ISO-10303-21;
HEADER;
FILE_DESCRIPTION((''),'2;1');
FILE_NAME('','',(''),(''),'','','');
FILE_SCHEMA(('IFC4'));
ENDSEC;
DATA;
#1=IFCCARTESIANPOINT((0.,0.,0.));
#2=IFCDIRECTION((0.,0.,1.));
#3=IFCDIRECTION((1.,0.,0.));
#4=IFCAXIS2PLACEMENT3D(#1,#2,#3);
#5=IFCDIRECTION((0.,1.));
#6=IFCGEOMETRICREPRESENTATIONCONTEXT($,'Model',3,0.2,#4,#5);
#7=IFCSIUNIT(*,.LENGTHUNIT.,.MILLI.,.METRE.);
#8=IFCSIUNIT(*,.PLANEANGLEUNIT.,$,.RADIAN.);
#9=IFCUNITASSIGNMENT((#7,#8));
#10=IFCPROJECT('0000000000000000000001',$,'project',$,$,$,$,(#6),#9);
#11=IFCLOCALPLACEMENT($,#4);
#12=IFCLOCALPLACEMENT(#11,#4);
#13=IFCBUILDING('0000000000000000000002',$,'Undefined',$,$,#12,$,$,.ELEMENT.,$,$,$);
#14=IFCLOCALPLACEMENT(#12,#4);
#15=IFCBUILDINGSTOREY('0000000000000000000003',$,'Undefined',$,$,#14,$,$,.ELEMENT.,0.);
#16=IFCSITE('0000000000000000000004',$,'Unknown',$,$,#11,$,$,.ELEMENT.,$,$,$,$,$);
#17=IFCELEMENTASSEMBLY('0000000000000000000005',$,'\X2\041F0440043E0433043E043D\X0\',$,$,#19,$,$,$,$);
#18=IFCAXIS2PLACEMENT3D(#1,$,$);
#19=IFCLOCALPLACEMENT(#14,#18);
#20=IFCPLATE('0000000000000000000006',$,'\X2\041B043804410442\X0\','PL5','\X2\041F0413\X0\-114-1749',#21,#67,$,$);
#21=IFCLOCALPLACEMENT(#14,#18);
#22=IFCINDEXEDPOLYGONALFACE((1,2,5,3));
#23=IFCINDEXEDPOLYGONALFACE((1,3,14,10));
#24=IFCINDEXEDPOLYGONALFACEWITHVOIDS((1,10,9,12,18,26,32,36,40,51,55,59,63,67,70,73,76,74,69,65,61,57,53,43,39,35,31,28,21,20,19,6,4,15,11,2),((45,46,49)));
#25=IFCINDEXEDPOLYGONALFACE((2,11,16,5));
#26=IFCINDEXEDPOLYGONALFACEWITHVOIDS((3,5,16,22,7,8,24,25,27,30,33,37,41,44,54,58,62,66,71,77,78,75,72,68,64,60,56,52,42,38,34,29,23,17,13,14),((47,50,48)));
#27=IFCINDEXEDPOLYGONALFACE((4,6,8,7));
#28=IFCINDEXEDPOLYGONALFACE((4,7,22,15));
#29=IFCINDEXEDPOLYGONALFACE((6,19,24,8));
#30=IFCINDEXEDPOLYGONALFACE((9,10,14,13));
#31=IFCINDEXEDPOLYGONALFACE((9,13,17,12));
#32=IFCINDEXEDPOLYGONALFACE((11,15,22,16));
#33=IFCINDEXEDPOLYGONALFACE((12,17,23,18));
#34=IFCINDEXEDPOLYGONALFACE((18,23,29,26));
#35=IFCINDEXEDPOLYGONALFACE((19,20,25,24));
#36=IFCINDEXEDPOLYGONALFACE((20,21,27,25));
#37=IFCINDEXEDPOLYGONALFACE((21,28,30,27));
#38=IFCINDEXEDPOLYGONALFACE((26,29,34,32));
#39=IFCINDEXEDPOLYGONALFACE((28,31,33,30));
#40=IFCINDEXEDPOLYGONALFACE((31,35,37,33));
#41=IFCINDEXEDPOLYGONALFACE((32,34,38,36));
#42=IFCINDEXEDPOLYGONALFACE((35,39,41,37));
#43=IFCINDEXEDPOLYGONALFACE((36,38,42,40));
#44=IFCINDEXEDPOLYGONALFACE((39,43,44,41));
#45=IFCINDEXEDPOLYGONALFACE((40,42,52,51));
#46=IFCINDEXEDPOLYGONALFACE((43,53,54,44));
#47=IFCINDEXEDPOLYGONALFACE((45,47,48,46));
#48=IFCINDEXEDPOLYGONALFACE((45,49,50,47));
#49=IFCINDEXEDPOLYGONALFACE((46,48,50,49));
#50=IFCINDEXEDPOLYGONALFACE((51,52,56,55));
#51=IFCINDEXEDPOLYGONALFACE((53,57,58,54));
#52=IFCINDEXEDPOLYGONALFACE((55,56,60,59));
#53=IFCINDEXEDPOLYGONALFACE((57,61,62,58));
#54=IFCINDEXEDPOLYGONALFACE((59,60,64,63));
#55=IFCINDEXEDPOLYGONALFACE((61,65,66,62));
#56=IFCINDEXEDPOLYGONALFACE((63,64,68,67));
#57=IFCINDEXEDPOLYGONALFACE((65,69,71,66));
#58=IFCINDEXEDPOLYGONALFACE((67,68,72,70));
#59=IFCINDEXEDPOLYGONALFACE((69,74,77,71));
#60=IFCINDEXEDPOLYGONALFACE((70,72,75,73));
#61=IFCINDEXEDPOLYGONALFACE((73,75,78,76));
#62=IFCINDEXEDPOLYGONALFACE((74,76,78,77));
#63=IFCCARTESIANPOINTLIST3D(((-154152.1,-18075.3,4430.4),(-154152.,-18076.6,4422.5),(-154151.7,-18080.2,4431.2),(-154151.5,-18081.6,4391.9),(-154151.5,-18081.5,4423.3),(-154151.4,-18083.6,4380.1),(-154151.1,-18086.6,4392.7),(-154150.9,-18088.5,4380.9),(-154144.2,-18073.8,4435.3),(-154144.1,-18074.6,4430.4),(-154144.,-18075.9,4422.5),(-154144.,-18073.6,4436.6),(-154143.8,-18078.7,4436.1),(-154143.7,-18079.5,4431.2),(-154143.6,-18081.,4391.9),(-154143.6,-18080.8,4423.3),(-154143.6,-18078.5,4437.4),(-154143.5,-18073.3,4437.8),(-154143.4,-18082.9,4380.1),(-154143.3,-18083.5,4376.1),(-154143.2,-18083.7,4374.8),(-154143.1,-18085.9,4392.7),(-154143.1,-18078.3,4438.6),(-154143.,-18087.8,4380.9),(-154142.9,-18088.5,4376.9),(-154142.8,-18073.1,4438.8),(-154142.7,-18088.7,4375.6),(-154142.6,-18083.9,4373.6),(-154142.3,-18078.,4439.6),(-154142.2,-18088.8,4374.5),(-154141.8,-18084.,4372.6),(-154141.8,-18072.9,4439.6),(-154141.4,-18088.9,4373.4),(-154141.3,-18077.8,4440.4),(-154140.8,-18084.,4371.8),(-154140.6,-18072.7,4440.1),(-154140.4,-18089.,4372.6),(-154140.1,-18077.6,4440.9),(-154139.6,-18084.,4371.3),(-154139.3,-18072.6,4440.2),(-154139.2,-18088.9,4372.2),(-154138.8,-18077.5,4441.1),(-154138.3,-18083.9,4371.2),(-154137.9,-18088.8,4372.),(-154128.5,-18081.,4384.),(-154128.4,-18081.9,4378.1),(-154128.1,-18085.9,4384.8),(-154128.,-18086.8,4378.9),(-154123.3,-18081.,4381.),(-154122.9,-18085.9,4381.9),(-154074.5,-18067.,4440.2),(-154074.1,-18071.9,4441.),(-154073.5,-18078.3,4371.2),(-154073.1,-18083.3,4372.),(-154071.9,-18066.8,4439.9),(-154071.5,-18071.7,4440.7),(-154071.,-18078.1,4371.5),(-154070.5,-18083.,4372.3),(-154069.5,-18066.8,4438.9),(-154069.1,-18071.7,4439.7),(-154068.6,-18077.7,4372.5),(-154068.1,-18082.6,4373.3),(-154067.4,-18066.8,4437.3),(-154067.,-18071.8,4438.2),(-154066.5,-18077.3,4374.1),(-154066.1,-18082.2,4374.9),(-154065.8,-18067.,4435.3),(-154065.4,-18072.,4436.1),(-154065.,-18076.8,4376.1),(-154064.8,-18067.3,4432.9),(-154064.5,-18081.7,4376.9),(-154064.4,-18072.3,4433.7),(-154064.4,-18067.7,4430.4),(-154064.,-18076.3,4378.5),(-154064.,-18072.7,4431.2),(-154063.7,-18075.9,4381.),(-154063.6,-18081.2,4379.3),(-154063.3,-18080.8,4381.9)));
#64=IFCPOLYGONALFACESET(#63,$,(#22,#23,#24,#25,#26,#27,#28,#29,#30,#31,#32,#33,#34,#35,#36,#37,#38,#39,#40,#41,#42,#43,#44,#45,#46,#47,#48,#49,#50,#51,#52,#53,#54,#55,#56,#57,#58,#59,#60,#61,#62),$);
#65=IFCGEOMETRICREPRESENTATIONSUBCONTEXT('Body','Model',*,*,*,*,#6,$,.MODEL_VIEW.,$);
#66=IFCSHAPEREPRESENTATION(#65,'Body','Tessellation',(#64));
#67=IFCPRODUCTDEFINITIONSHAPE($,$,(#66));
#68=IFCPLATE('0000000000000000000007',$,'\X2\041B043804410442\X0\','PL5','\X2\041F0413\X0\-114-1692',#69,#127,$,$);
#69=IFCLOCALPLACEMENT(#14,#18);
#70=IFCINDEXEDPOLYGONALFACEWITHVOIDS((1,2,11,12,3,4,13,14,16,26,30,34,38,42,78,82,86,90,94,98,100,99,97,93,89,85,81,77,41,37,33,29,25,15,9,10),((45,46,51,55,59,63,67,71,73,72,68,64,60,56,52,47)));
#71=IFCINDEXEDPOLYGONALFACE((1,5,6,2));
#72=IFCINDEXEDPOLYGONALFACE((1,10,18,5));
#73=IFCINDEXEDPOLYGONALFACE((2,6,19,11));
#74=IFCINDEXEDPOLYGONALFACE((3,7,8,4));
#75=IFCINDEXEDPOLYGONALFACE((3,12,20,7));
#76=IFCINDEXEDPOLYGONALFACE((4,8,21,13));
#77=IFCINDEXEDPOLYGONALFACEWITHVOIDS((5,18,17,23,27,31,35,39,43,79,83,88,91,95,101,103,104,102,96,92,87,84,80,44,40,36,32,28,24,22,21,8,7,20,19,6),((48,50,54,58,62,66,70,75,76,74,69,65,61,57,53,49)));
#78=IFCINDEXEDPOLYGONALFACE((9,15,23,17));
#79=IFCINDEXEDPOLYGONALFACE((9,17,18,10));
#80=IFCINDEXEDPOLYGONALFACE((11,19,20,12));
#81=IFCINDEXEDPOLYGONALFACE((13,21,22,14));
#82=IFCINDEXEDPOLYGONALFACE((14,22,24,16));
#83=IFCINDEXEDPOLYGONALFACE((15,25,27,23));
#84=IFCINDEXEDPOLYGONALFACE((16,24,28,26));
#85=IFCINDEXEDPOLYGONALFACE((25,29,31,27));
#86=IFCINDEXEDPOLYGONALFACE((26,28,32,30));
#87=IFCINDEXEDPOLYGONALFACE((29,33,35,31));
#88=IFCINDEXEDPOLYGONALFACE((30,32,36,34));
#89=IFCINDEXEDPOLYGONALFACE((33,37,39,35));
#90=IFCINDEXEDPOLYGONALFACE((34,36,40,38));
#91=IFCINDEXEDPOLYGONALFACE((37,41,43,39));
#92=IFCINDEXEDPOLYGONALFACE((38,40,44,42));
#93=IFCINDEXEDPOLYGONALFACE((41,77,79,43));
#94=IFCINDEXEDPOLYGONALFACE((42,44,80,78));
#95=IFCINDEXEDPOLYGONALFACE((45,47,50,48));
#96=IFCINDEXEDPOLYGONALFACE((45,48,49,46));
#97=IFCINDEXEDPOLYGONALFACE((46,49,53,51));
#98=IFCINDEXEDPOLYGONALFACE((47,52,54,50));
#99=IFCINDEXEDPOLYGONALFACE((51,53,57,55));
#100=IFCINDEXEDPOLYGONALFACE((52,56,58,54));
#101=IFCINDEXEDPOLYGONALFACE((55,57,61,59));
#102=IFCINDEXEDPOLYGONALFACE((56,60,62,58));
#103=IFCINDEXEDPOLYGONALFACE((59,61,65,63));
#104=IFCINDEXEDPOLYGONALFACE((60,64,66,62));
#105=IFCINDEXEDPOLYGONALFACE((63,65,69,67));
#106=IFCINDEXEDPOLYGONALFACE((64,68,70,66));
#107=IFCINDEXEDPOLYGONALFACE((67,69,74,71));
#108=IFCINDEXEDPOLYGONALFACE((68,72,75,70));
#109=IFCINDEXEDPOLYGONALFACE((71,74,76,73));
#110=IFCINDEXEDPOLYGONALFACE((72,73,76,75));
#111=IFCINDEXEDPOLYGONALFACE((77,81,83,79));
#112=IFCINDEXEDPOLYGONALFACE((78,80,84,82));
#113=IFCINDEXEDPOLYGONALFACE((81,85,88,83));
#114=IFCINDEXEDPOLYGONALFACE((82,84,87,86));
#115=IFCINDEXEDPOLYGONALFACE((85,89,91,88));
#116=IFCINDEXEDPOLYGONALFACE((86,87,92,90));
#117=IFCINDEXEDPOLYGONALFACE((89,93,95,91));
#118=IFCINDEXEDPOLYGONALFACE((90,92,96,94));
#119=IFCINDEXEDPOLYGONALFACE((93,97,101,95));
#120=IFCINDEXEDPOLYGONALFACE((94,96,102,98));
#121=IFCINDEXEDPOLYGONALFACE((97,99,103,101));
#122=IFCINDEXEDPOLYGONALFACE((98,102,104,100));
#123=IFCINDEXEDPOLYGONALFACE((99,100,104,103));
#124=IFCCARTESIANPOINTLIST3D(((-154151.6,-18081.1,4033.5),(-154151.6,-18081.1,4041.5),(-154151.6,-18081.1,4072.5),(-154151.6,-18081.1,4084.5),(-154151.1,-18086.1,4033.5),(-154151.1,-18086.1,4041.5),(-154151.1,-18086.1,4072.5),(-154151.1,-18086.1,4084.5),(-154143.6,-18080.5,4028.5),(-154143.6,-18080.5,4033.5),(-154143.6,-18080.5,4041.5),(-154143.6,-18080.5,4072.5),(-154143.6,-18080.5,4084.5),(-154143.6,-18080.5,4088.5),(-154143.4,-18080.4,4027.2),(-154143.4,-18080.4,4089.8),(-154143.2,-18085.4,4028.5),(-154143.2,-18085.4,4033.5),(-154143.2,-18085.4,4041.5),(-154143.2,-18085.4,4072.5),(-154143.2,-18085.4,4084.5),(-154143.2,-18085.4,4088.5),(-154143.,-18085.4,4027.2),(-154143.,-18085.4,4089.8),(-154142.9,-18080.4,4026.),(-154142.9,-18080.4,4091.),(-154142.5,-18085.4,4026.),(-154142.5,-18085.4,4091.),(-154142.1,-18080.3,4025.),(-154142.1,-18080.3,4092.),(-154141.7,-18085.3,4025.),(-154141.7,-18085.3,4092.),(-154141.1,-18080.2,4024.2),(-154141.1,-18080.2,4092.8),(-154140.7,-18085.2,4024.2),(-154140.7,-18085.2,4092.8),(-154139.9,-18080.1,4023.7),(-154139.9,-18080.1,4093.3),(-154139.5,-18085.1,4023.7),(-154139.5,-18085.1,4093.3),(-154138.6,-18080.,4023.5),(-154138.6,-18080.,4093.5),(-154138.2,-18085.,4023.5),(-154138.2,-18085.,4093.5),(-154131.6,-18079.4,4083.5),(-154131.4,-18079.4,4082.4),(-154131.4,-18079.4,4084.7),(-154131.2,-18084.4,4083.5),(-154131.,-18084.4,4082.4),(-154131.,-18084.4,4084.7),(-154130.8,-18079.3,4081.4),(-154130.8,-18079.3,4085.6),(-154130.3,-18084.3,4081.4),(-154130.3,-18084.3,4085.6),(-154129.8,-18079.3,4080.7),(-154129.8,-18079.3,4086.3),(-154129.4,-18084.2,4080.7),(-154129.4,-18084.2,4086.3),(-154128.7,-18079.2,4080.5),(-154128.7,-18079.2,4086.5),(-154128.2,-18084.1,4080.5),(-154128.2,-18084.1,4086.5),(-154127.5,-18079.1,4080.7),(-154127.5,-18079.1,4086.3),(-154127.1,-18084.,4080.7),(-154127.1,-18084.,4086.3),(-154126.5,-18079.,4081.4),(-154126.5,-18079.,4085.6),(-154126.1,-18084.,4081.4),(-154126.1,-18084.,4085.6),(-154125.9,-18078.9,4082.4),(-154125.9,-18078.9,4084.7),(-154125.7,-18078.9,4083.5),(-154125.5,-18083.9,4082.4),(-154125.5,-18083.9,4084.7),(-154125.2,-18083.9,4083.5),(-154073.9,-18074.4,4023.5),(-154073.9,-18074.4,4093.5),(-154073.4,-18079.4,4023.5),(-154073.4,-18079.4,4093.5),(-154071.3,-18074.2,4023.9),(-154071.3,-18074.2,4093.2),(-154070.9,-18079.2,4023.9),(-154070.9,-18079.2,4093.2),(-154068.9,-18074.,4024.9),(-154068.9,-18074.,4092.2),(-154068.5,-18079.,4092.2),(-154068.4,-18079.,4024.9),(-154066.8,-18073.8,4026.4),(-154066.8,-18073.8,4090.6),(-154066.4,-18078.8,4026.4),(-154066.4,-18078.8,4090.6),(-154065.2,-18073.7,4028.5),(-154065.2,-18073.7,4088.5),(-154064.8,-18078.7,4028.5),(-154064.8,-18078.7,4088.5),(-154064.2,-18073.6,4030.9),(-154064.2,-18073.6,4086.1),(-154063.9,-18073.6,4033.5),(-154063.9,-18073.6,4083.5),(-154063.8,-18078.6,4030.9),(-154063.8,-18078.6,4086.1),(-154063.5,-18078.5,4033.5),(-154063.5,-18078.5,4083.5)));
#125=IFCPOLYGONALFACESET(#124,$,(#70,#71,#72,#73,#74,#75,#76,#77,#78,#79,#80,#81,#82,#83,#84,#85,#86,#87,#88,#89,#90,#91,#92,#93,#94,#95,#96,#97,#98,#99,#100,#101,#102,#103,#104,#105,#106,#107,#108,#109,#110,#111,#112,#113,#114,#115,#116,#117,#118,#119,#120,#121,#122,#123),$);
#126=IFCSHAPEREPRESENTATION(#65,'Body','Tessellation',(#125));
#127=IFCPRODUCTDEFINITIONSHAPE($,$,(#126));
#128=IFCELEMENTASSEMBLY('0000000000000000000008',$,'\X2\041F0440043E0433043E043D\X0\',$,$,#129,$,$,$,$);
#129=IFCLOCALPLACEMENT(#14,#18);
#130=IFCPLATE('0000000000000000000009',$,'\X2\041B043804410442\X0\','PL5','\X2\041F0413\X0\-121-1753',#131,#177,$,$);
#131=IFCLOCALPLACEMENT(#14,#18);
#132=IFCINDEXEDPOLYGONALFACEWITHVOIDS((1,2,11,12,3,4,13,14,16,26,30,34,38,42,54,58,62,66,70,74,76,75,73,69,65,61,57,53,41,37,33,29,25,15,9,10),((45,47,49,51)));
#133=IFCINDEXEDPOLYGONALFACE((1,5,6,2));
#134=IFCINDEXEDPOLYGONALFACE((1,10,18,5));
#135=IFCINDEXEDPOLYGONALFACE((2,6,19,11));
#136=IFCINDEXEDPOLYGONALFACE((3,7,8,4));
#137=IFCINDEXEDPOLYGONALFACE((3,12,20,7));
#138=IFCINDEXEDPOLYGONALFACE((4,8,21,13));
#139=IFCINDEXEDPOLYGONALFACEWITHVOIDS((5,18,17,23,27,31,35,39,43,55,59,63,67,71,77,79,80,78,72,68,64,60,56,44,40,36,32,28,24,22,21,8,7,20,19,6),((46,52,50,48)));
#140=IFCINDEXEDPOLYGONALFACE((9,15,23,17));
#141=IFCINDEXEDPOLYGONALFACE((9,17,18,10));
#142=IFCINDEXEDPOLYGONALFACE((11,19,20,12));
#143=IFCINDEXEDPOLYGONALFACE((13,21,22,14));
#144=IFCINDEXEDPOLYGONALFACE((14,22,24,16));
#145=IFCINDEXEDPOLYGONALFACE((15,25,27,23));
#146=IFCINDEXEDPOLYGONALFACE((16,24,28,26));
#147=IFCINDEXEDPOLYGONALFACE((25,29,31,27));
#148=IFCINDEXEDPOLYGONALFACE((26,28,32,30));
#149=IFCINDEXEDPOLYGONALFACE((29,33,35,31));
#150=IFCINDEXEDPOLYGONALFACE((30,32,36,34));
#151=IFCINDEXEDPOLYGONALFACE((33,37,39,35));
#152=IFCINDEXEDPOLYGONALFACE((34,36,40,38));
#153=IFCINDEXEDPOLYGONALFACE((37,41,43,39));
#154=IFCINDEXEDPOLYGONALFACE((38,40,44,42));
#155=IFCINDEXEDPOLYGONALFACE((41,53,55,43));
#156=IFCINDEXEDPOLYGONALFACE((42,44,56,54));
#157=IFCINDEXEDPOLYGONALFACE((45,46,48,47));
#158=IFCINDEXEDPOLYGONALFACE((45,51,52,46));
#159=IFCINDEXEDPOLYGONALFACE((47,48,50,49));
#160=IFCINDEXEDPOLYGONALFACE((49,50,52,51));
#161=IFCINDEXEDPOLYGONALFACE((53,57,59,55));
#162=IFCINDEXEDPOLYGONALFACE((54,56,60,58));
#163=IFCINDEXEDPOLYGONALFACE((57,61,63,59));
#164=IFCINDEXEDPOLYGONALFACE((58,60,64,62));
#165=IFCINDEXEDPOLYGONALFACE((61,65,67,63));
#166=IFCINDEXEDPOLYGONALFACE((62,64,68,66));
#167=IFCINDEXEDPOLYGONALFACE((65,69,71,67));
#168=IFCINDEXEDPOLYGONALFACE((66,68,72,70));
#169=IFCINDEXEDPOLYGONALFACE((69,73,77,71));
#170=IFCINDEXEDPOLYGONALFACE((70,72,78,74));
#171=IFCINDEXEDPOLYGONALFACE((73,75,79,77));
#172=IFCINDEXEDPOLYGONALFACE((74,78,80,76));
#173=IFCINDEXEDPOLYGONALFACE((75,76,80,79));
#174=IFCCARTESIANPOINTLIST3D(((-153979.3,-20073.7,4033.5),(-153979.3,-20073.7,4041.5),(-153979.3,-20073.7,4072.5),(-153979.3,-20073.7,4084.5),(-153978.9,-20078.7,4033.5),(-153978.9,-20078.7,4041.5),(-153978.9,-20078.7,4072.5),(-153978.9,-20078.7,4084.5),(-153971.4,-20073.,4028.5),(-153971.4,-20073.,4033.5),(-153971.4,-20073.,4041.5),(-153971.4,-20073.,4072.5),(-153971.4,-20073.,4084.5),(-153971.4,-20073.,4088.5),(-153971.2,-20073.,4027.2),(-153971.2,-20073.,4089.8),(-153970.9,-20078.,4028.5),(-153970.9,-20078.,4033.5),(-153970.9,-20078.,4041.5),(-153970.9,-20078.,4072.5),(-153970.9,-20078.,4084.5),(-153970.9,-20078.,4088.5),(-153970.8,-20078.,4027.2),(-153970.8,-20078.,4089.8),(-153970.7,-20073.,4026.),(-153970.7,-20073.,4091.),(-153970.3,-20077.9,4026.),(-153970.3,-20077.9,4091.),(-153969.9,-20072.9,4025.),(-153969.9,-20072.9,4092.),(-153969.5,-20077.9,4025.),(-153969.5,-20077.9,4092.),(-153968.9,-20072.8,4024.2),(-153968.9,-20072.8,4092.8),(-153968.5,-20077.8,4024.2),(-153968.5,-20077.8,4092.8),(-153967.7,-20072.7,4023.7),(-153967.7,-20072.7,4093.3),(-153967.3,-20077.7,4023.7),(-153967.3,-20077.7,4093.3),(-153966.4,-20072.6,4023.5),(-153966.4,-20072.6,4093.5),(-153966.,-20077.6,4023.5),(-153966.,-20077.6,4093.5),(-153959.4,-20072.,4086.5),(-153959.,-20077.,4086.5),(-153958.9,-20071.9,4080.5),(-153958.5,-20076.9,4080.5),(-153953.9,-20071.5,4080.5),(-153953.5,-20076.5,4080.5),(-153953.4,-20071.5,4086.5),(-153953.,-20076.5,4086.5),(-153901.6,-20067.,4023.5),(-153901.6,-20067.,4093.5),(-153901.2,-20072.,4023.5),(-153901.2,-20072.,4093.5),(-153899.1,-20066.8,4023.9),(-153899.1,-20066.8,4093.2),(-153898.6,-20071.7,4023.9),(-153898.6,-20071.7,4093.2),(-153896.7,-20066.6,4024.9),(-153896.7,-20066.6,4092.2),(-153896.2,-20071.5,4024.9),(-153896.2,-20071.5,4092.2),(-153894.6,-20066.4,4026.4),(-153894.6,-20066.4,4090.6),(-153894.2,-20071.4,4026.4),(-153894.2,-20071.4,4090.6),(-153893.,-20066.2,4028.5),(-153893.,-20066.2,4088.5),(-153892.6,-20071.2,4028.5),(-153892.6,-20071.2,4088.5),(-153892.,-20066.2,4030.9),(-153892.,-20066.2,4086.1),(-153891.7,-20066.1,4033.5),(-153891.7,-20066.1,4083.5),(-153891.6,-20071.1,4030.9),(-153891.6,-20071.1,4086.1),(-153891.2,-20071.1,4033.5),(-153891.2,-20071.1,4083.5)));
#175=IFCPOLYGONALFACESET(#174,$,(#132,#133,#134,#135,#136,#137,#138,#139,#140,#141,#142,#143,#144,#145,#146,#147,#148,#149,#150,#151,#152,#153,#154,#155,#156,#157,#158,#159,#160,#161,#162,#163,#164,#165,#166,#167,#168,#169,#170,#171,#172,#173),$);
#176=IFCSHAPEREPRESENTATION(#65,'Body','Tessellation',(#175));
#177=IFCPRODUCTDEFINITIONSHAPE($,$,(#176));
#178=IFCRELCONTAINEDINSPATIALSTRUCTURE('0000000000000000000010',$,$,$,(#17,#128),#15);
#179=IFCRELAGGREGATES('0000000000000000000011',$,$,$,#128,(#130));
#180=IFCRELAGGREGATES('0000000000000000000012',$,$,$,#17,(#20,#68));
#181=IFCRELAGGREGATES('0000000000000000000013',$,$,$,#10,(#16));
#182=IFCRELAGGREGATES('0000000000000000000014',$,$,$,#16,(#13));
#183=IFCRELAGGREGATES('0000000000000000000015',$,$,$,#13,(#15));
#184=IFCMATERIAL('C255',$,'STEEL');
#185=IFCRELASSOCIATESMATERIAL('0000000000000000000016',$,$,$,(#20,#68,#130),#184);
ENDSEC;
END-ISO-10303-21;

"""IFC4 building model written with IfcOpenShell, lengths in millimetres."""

from ifc_helpers import new_model, si_unit, direction, frame, origin_with_axes, place, context, subcontext, project, spatial, line, arc, indexed_curve, outline, extrude, material, element, aggregate, save


model = new_model("IFC4")

# Units and contexts
model_context = context("Model", 3, precision=0.2, world=origin_with_axes(), true_north=direction((0.0, 1.0)))
body_context = subcontext(model_context, "Body", "Model", "MODEL_VIEW")
ifc_project = project(units=[si_unit("LENGTHUNIT", "METRE", prefix="MILLI"), si_unit("PLANEANGLEUNIT", "RADIAN")], contexts=[model_context])

# Site, building, storey
site_placement = place(None, origin_with_axes())
site = spatial("IfcSite", under=ifc_project, at=site_placement, Name="Unknown", CompositionType="ELEMENT")
building_placement = place(site_placement, origin_with_axes())
building = spatial("IfcBuilding", under=site, at=building_placement, Name="Undefined", CompositionType="ELEMENT")
storey_placement = place(building_placement, origin_with_axes())
storey = spatial("IfcBuildingStorey", under=building, at=storey_placement, Name="Undefined", CompositionType="ELEMENT", Elevation=0.0)

# Shared definitions
ifc_material_1 = material(Name="C255", Category="STEEL")

# Element assembly, plates, voiding features
assembly_1_placement = place(storey_placement, frame((-154183.2, -18086.4, 3718.5), z_axis=(0.086114, -0.996285, 0.0), x_axis=(0.0, 0.0, 1.0)))
assembly_1 = element("IfcElementAssembly", 1, at=assembly_1_placement, inside=storey, Name="Прогон")
plate_1_placement = place(assembly_1_placement, frame((722.1, -120.0, -7.5), z_axis=(-0.162881, -0.000054, -0.986646), x_axis=(-0.986646, 0.000078, 0.162881)))
plate_1 = element("IfcPlate", 2, at=plate_1_placement, material=ifc_material_1, Name="Лист", Description="PL5", ObjectType="ПГ-114-1749", context=body_context, shape_type="SolidModel", body=[
    extrude(outline(indexed_curve([(0.0, 10.0), (2.9, 2.9), (10.0, 0.0), (60.0, 0.0), (67.1, 2.9), (70.0, 10.0), (70.0, 75.0), (68.5, 78.5), (65.0, 80.0), (61.0, 80.0), (61.0, 88.0), (49.0, 88.0), (49.0, 80.0), (18.0, 80.0), (18.0, 88.0), (10.0, 88.0), (10.0, 80.0), (5.0, 80.0), (1.5, 78.5), (0.0, 75.0)], segments=[arc(1, 2, 3), line(3, 4), arc(4, 5, 6), line(6, 7), arc(7, 8, 9), line(9, 10, 11, 12, 13, 14, 15, 16, 17, 18), arc(18, 19, 20), line(20, 1)])), frame((0.0, 0.0, 2.5), z_axis=(0.0, 0.0, 1.0), x_axis=(1.0, 0.0, 0.0)), (0.0, 0.0, -1.0), 5.0),
])
voiding_feature_1_placement = place(plate_1_placement, frame((60.0, 65.0, 6.0), z_axis=(-0.000054, -1.0, 0.000034), x_axis=(0.0, -0.000034, -1.0)))
element("IfcVoidingFeature", 3, at=voiding_feature_1_placement, cuts=plate_1, Name="Балка", ObjectType="(?)", PredefinedType="HOLE", context=body_context, shape_type="SolidModel", body=[
    extrude(outline(indexed_curve([(0.0, -3.0), (5.2, 0.0), (0.0, 3.0)], segments=[line(1, 2, 3, 1)])), frame((0.0, 0.0, 0.0), z_axis=(-1.0, 0.0, 0.0), x_axis=(0.0, 0.0, 1.0)), (0.0, 0.0, -1.0), 12.0),
])
plate_2_placement = place(assembly_1_placement, frame((305.0, -120.0, 0.0), z_axis=(0.0, -0.000057, 1.0), x_axis=(1.0, 0.000024, 0.0)))
plate_2 = element("IfcPlate", 4, at=plate_2_placement, material=ifc_material_1, Name="Лист", Description="PL5", ObjectType="ПГ-114-1692", context=body_context, shape_type="SolidModel", body=[
    extrude(outline(indexed_curve([(0.0, 10.0), (2.9, 2.9), (10.0, 0.0), (60.0, 0.0), (67.1, 2.9), (70.0, 10.0), (70.0, 75.0), (68.5, 78.5), (65.0, 80.0), (61.0, 80.0), (61.0, 88.0), (49.0, 88.0), (49.0, 80.0), (18.0, 80.0), (18.0, 88.0), (10.0, 88.0), (10.0, 80.0), (5.0, 80.0), (1.5, 78.5), (0.0, 75.0)], segments=[arc(1, 2, 3), line(3, 4), arc(4, 5, 6), line(6, 7), arc(7, 8, 9), line(9, 10, 11, 12, 13, 14, 15, 16, 17, 18), arc(18, 19, 20), line(20, 1)])), frame((0.0, 0.0, 2.5), z_axis=(0.0, 0.0, 1.0), x_axis=(1.0, 0.0, 0.0)), (0.0, 0.0, -1.0), 5.0),
])
voiding_feature_2_placement = place(plate_2_placement, frame((60.0, 65.0, 6.0), z_axis=(-0.000054, -1.0, 0.000034), x_axis=(0.0, -0.000034, -1.0)))
element("IfcVoidingFeature", 5, at=voiding_feature_2_placement, cuts=plate_2, Name="Балка", ObjectType="(?)", PredefinedType="HOLE", context=body_context, shape_type="SolidModel", body=[
    extrude(outline(indexed_curve([(3.0, 0.0), (2.8, 1.1), (2.1, 2.1), (1.1, 2.8), (0.0, 3.0), (-1.1, 2.8), (-2.1, 2.1), (-2.8, 1.1), (-3.0, 0.0), (-2.8, -1.1), (-2.1, -2.1), (-1.1, -2.8), (0.0, -3.0), (1.1, -2.8), (2.1, -2.1), (2.8, -1.1)], segments=[line(1, 2, 3, 4, 5, 6, 7, 8, 9, 10, 11, 12, 13, 14, 15, 16, 1)])), frame((0.0, 0.0, 0.0), z_axis=(-1.0, 0.0, 0.0), x_axis=(0.0, 0.0, 1.0)), (0.0, 0.0, -1.0), 12.0),
])

# Element assembly, plate, voiding feature
assembly_2_placement = place(storey_placement, frame((-154011.0, -20079.0, 3798.5), z_axis=(0.086114, -0.996285, 0.0), x_axis=(0.0, 0.0, 1.0)))
assembly_2 = element("IfcElementAssembly", 6, at=assembly_2_placement, inside=storey, Name="Прогон")
plate_3_placement = place(assembly_2_placement, frame((225.0, -120.0, 0.0), z_axis=(0.0, -0.000057, 1.0), x_axis=(1.0, 0.000024, 0.0)))
plate_3 = element("IfcPlate", 7, at=plate_3_placement, material=ifc_material_1, Name="Лист", Description="PL5", ObjectType="ПГ-121-1753", context=body_context, shape_type="SolidModel", body=[
    extrude(outline(indexed_curve([(0.0, 10.0), (2.9, 2.9), (10.0, 0.0), (60.0, 0.0), (67.1, 2.9), (70.0, 10.0), (70.0, 75.0), (68.5, 78.5), (65.0, 80.0), (61.0, 80.0), (61.0, 88.0), (49.0, 88.0), (49.0, 80.0), (18.0, 80.0), (18.0, 88.0), (10.0, 88.0), (10.0, 80.0), (5.0, 80.0), (1.5, 78.5), (0.0, 75.0)], segments=[arc(1, 2, 3), line(3, 4), arc(4, 5, 6), line(6, 7), arc(7, 8, 9), line(9, 10, 11, 12, 13, 14, 15, 16, 17, 18), arc(18, 19, 20), line(20, 1)])), frame((0.0, 0.0, 2.5), z_axis=(0.0, 0.0, 1.0), x_axis=(1.0, 0.0, 0.0)), (0.0, 0.0, -1.0), 5.0),
])
voiding_feature_3_placement = place(plate_3_placement, frame((60.0, 65.0, 6.0), z_axis=(-0.000054, -1.0, 0.000034), x_axis=(0.0, -0.000034, -1.0)))
element("IfcVoidingFeature", 8, at=voiding_feature_3_placement, cuts=plate_3, Name="Балка", ObjectType="(?)", PredefinedType="HOLE", context=body_context, shape_type="SolidModel", body=[
    extrude(outline(indexed_curve([(2.5, -3.0), (3.0, 3.0), (-3.0, 3.0), (-2.5, -3.0)], segments=[line(1, 2, 3, 4, 1)])), frame((0.0, 0.0, 0.0), z_axis=(-1.0, 0.0, 0.0), x_axis=(0.0, 0.0, 1.0)), (0.0, 0.0, -1.0), 12.0),
])
aggregate(assembly_2, [plate_3])

aggregate(assembly_1, [plate_1, plate_2])

save(model, "model.ifc")
